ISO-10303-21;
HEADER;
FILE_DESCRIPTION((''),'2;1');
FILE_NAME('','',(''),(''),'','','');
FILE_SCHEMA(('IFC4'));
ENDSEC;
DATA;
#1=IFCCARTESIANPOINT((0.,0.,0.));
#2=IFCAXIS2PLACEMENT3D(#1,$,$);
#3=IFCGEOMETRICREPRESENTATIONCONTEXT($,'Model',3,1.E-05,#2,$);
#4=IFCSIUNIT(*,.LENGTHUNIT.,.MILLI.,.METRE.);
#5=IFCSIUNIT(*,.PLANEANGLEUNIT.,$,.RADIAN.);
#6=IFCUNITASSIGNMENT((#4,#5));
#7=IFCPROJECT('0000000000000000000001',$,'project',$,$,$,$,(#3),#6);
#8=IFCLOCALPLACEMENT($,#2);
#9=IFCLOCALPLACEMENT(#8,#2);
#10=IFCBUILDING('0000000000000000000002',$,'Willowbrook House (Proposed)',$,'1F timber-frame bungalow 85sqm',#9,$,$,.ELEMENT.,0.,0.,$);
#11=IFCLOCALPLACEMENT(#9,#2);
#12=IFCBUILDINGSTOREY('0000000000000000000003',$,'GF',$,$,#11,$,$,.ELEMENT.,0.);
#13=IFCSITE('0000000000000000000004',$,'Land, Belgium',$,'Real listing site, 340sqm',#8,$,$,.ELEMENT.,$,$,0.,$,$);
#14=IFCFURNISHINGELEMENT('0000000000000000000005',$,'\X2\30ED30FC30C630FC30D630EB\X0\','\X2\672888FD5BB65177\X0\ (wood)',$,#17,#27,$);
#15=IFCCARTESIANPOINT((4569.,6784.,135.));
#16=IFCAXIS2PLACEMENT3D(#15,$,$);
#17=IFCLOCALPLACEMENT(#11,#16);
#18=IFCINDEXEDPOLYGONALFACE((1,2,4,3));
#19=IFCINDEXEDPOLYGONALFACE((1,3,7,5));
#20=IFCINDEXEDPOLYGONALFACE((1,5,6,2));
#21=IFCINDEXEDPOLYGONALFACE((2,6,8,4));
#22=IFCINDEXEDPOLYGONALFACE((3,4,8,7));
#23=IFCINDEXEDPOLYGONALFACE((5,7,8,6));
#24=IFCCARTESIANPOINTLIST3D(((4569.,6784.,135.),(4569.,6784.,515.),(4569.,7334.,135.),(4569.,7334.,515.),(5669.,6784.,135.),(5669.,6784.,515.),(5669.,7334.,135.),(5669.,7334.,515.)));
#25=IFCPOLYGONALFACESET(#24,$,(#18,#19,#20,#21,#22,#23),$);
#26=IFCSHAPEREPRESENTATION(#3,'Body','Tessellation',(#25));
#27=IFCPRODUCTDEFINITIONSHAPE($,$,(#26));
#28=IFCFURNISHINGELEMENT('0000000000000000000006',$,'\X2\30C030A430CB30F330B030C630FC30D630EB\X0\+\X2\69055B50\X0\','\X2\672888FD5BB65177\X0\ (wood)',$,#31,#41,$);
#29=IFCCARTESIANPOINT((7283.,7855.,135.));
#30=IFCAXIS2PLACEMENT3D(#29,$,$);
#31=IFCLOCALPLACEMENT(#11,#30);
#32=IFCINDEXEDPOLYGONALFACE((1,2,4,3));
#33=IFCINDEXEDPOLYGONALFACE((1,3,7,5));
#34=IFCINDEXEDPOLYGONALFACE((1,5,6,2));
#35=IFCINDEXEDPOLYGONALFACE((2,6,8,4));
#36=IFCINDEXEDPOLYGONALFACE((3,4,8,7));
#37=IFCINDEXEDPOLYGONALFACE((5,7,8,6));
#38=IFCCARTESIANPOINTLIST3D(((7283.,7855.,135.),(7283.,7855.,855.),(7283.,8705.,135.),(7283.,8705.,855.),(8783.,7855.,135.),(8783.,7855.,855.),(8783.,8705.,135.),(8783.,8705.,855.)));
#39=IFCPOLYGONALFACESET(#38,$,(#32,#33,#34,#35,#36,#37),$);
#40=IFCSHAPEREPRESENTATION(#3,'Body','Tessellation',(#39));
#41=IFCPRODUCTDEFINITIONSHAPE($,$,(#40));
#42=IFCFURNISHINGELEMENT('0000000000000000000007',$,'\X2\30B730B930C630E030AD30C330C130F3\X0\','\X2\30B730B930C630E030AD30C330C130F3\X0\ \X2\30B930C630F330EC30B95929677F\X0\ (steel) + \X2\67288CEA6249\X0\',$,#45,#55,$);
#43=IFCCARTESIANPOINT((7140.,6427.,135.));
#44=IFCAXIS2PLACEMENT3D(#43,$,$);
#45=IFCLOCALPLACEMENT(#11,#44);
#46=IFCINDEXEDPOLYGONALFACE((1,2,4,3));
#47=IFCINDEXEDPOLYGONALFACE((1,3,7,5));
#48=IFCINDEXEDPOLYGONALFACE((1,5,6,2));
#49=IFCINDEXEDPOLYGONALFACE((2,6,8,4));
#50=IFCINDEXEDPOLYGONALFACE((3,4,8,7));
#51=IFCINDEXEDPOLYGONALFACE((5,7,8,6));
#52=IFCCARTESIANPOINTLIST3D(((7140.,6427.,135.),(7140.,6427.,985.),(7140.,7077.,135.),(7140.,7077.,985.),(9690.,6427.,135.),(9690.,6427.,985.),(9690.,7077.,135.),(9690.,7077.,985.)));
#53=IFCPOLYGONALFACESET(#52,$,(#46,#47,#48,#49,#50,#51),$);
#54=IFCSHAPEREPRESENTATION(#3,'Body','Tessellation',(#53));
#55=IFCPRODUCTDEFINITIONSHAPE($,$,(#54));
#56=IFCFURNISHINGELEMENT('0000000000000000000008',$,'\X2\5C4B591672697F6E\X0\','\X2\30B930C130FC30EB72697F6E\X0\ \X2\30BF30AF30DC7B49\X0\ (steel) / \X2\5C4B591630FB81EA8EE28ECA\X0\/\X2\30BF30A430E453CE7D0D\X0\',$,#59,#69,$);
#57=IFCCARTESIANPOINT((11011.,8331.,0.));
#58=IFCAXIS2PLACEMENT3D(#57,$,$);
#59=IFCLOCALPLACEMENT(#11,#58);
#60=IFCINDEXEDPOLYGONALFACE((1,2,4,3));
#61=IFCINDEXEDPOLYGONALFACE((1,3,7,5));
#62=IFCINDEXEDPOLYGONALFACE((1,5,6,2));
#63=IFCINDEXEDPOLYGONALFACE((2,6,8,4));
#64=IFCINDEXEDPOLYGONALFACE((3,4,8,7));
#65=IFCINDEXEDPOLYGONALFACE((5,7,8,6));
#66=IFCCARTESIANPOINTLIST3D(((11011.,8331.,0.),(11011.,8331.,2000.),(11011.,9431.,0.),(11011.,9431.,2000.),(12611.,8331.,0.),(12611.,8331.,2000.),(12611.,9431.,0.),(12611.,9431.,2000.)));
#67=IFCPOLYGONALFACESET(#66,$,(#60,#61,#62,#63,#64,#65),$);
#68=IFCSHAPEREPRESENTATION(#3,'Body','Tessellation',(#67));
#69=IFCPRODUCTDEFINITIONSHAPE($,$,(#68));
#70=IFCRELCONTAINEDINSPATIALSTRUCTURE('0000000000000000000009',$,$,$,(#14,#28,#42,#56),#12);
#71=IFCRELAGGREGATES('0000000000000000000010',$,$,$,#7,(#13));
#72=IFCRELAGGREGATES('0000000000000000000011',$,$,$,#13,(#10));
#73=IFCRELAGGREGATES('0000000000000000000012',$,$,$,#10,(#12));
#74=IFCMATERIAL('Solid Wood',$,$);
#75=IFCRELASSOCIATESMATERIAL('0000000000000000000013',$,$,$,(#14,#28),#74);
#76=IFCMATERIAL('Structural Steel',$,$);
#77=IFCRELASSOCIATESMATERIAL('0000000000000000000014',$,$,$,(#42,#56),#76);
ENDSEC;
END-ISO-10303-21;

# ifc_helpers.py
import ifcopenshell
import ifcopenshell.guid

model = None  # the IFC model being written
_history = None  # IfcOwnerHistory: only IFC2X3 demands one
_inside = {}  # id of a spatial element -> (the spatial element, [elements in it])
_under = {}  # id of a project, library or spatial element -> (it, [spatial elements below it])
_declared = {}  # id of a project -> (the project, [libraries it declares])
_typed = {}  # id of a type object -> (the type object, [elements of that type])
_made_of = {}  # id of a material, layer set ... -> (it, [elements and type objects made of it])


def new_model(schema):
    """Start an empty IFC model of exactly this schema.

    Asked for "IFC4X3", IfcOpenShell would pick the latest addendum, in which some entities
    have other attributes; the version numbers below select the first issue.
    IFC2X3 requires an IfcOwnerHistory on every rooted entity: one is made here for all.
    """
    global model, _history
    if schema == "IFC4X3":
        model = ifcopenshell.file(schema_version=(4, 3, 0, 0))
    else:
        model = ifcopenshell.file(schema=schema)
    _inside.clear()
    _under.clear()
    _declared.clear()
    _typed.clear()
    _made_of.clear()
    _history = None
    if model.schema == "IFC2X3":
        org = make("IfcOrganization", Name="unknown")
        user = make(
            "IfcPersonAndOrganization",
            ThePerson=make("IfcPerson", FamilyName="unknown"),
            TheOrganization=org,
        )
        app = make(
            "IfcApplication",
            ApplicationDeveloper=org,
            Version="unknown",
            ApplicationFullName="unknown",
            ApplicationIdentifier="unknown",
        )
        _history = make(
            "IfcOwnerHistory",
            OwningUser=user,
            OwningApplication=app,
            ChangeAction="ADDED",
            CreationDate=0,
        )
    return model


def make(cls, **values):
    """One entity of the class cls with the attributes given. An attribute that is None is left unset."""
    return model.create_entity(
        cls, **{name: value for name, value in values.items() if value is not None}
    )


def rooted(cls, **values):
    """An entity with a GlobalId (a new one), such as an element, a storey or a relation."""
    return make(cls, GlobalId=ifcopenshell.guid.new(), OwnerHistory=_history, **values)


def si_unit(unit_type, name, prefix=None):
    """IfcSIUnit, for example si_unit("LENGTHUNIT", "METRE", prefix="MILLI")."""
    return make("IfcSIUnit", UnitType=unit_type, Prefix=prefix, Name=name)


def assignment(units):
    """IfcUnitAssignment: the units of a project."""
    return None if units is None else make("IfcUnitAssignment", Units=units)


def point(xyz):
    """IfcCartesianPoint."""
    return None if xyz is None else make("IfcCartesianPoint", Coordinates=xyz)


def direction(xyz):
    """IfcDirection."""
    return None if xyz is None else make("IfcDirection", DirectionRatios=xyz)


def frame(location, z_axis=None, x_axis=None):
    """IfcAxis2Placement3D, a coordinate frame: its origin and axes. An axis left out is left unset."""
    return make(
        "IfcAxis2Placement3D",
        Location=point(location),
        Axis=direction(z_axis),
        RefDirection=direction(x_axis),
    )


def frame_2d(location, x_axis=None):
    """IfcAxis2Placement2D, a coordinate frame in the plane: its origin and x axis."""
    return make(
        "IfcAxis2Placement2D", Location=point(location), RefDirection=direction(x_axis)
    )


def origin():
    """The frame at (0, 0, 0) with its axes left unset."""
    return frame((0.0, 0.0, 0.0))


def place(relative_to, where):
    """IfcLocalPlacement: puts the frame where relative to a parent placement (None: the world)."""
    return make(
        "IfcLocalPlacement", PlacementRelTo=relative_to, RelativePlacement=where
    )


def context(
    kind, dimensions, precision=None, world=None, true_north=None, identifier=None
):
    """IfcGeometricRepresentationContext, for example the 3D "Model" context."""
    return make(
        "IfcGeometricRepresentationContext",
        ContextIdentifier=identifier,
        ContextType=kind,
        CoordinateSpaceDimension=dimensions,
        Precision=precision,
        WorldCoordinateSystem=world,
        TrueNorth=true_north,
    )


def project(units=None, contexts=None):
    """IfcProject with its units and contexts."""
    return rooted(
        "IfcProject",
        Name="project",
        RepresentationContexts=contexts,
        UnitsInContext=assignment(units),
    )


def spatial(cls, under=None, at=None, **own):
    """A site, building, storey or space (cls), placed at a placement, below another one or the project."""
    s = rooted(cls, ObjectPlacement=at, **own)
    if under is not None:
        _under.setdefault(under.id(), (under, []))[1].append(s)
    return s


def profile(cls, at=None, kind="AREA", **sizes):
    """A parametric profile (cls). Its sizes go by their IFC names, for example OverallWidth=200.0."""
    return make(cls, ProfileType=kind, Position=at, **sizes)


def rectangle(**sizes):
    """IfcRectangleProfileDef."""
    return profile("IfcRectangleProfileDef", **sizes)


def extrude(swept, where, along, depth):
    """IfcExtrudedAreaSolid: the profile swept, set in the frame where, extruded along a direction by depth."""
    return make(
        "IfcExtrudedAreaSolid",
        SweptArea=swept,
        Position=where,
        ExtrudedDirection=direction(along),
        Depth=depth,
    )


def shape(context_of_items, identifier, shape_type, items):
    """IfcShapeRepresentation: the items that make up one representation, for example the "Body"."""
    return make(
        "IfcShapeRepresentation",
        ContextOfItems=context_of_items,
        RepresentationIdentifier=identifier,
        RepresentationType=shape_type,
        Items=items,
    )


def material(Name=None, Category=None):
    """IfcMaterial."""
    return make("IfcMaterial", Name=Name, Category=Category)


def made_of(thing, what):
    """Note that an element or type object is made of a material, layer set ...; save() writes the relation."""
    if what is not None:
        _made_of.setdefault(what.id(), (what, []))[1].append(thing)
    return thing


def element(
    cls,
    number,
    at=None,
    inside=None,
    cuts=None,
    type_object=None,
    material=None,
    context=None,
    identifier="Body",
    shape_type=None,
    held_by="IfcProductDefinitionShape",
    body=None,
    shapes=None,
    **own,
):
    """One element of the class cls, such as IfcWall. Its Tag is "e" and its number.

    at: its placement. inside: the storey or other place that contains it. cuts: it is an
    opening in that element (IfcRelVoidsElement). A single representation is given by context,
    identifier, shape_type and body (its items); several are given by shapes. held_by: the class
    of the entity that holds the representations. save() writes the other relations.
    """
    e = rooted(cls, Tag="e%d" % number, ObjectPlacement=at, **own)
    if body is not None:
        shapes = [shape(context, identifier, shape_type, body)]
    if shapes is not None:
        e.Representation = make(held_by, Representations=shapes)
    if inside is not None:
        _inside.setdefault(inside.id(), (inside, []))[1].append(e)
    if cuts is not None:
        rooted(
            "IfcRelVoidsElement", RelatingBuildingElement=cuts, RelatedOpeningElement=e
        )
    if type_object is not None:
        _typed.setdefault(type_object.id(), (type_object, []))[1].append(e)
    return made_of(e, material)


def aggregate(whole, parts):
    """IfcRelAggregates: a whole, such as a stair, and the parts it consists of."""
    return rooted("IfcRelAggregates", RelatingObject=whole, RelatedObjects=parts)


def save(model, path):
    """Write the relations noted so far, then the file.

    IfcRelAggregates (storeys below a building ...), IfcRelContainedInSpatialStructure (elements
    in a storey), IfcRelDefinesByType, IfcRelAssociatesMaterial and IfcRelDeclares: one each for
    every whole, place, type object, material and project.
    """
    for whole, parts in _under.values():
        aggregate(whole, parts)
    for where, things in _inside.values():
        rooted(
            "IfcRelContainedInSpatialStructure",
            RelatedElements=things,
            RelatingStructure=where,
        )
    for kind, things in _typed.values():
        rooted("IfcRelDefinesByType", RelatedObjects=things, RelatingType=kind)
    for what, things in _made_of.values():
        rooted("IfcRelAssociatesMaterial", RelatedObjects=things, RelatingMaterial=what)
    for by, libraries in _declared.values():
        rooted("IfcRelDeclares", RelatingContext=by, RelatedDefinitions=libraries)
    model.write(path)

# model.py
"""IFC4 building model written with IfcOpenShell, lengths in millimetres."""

from ifc_helpers import new_model, si_unit, frame, frame_2d, origin, place, context, project, spatial, rectangle, extrude, material, element, save


model = new_model("IFC4")

# Units and contexts
model_context = context("Model", 3, precision=1e-05, world=origin())
ifc_project = project(units=[si_unit("LENGTHUNIT", "METRE", prefix="MILLI"), si_unit("PLANEANGLEUNIT", "RADIAN")], contexts=[model_context])

# Site, building, storey
site_placement = place(None, origin())
site = spatial("IfcSite", under=ifc_project, at=site_placement, Name="Land, Belgium", ObjectType="Real listing site, 340sqm", CompositionType="ELEMENT", RefElevation=0.0)
building_placement = place(site_placement, origin())
building = spatial("IfcBuilding", under=site, at=building_placement, Name="Willowbrook House (Proposed)", ObjectType="1F timber-frame bungalow 85sqm", CompositionType="ELEMENT", ElevationOfRefHeight=0.0, ElevationOfTerrain=0.0)
storey_placement = place(building_placement, origin())
storey = spatial("IfcBuildingStorey", under=building, at=storey_placement, Name="GF", CompositionType="ELEMENT", Elevation=0.0)

# Shared definitions
ifc_material_1 = material(Name="Solid Wood")

# Shared definitions
ifc_material_2 = material(Name="Structural Steel")

# Furnishing elements
furnishing_1_placement = place(storey_placement, frame((4569.0, 6784.0, 135.0)))
element("IfcFurnishingElement", 1, at=furnishing_1_placement, inside=storey, material=ifc_material_1, Name="ローテーブル", Description="木製家具 (wood)", context=model_context, shape_type="SweptSolid", body=[
    extrude(rectangle(XDim=1100.0, YDim=550.0, at=frame_2d((550.0, 275.0))), frame((4569.0, 6784.0, 135.0)), (0.0, 0.0, 1.0), 380.0),
])
furnishing_2_placement = place(storey_placement, frame((7283.0, 7855.0, 135.0)))
element("IfcFurnishingElement", 2, at=furnishing_2_placement, inside=storey, material=ifc_material_1, Name="ダイニングテーブル+椅子", Description="木製家具 (wood)", context=model_context, shape_type="SweptSolid", body=[
    extrude(rectangle(XDim=1500.0, YDim=850.0, at=frame_2d((750.0, 425.0))), frame((7283.0, 7855.0, 135.0)), (0.0, 0.0, 1.0), 720.0),
])
furnishing_3_placement = place(storey_placement, frame((7140.0, 6427.0, 135.0)))
element("IfcFurnishingElement", 3, at=furnishing_3_placement, inside=storey, material=ifc_material_2, Name="システムキッチン", Description="システムキッチン ステンレス天板 (steel) + 木質扉", context=model_context, shape_type="SweptSolid", body=[
    extrude(rectangle(XDim=2550.0, YDim=650.0, at=frame_2d((1275.0, 325.0))), frame((7140.0, 6427.0, 135.0)), (0.0, 0.0, 1.0), 850.0),
])
furnishing_4_placement = place(storey_placement, frame((11011.0, 8331.0, 0.0)))
element("IfcFurnishingElement", 4, at=furnishing_4_placement, inside=storey, material=ifc_material_2, Name="屋外物置", Description="スチール物置 タクボ等 (steel) / 屋外・自転車/タイヤ収納", context=model_context, shape_type="SweptSolid", body=[
    extrude(rectangle(XDim=1600.0, YDim=1100.0, at=frame_2d((800.0, 550.0))), frame((11011.0, 8331.0, 0.0)), (0.0, 0.0, 1.0), 2000.0),
])

save(model, "model.ifc")
